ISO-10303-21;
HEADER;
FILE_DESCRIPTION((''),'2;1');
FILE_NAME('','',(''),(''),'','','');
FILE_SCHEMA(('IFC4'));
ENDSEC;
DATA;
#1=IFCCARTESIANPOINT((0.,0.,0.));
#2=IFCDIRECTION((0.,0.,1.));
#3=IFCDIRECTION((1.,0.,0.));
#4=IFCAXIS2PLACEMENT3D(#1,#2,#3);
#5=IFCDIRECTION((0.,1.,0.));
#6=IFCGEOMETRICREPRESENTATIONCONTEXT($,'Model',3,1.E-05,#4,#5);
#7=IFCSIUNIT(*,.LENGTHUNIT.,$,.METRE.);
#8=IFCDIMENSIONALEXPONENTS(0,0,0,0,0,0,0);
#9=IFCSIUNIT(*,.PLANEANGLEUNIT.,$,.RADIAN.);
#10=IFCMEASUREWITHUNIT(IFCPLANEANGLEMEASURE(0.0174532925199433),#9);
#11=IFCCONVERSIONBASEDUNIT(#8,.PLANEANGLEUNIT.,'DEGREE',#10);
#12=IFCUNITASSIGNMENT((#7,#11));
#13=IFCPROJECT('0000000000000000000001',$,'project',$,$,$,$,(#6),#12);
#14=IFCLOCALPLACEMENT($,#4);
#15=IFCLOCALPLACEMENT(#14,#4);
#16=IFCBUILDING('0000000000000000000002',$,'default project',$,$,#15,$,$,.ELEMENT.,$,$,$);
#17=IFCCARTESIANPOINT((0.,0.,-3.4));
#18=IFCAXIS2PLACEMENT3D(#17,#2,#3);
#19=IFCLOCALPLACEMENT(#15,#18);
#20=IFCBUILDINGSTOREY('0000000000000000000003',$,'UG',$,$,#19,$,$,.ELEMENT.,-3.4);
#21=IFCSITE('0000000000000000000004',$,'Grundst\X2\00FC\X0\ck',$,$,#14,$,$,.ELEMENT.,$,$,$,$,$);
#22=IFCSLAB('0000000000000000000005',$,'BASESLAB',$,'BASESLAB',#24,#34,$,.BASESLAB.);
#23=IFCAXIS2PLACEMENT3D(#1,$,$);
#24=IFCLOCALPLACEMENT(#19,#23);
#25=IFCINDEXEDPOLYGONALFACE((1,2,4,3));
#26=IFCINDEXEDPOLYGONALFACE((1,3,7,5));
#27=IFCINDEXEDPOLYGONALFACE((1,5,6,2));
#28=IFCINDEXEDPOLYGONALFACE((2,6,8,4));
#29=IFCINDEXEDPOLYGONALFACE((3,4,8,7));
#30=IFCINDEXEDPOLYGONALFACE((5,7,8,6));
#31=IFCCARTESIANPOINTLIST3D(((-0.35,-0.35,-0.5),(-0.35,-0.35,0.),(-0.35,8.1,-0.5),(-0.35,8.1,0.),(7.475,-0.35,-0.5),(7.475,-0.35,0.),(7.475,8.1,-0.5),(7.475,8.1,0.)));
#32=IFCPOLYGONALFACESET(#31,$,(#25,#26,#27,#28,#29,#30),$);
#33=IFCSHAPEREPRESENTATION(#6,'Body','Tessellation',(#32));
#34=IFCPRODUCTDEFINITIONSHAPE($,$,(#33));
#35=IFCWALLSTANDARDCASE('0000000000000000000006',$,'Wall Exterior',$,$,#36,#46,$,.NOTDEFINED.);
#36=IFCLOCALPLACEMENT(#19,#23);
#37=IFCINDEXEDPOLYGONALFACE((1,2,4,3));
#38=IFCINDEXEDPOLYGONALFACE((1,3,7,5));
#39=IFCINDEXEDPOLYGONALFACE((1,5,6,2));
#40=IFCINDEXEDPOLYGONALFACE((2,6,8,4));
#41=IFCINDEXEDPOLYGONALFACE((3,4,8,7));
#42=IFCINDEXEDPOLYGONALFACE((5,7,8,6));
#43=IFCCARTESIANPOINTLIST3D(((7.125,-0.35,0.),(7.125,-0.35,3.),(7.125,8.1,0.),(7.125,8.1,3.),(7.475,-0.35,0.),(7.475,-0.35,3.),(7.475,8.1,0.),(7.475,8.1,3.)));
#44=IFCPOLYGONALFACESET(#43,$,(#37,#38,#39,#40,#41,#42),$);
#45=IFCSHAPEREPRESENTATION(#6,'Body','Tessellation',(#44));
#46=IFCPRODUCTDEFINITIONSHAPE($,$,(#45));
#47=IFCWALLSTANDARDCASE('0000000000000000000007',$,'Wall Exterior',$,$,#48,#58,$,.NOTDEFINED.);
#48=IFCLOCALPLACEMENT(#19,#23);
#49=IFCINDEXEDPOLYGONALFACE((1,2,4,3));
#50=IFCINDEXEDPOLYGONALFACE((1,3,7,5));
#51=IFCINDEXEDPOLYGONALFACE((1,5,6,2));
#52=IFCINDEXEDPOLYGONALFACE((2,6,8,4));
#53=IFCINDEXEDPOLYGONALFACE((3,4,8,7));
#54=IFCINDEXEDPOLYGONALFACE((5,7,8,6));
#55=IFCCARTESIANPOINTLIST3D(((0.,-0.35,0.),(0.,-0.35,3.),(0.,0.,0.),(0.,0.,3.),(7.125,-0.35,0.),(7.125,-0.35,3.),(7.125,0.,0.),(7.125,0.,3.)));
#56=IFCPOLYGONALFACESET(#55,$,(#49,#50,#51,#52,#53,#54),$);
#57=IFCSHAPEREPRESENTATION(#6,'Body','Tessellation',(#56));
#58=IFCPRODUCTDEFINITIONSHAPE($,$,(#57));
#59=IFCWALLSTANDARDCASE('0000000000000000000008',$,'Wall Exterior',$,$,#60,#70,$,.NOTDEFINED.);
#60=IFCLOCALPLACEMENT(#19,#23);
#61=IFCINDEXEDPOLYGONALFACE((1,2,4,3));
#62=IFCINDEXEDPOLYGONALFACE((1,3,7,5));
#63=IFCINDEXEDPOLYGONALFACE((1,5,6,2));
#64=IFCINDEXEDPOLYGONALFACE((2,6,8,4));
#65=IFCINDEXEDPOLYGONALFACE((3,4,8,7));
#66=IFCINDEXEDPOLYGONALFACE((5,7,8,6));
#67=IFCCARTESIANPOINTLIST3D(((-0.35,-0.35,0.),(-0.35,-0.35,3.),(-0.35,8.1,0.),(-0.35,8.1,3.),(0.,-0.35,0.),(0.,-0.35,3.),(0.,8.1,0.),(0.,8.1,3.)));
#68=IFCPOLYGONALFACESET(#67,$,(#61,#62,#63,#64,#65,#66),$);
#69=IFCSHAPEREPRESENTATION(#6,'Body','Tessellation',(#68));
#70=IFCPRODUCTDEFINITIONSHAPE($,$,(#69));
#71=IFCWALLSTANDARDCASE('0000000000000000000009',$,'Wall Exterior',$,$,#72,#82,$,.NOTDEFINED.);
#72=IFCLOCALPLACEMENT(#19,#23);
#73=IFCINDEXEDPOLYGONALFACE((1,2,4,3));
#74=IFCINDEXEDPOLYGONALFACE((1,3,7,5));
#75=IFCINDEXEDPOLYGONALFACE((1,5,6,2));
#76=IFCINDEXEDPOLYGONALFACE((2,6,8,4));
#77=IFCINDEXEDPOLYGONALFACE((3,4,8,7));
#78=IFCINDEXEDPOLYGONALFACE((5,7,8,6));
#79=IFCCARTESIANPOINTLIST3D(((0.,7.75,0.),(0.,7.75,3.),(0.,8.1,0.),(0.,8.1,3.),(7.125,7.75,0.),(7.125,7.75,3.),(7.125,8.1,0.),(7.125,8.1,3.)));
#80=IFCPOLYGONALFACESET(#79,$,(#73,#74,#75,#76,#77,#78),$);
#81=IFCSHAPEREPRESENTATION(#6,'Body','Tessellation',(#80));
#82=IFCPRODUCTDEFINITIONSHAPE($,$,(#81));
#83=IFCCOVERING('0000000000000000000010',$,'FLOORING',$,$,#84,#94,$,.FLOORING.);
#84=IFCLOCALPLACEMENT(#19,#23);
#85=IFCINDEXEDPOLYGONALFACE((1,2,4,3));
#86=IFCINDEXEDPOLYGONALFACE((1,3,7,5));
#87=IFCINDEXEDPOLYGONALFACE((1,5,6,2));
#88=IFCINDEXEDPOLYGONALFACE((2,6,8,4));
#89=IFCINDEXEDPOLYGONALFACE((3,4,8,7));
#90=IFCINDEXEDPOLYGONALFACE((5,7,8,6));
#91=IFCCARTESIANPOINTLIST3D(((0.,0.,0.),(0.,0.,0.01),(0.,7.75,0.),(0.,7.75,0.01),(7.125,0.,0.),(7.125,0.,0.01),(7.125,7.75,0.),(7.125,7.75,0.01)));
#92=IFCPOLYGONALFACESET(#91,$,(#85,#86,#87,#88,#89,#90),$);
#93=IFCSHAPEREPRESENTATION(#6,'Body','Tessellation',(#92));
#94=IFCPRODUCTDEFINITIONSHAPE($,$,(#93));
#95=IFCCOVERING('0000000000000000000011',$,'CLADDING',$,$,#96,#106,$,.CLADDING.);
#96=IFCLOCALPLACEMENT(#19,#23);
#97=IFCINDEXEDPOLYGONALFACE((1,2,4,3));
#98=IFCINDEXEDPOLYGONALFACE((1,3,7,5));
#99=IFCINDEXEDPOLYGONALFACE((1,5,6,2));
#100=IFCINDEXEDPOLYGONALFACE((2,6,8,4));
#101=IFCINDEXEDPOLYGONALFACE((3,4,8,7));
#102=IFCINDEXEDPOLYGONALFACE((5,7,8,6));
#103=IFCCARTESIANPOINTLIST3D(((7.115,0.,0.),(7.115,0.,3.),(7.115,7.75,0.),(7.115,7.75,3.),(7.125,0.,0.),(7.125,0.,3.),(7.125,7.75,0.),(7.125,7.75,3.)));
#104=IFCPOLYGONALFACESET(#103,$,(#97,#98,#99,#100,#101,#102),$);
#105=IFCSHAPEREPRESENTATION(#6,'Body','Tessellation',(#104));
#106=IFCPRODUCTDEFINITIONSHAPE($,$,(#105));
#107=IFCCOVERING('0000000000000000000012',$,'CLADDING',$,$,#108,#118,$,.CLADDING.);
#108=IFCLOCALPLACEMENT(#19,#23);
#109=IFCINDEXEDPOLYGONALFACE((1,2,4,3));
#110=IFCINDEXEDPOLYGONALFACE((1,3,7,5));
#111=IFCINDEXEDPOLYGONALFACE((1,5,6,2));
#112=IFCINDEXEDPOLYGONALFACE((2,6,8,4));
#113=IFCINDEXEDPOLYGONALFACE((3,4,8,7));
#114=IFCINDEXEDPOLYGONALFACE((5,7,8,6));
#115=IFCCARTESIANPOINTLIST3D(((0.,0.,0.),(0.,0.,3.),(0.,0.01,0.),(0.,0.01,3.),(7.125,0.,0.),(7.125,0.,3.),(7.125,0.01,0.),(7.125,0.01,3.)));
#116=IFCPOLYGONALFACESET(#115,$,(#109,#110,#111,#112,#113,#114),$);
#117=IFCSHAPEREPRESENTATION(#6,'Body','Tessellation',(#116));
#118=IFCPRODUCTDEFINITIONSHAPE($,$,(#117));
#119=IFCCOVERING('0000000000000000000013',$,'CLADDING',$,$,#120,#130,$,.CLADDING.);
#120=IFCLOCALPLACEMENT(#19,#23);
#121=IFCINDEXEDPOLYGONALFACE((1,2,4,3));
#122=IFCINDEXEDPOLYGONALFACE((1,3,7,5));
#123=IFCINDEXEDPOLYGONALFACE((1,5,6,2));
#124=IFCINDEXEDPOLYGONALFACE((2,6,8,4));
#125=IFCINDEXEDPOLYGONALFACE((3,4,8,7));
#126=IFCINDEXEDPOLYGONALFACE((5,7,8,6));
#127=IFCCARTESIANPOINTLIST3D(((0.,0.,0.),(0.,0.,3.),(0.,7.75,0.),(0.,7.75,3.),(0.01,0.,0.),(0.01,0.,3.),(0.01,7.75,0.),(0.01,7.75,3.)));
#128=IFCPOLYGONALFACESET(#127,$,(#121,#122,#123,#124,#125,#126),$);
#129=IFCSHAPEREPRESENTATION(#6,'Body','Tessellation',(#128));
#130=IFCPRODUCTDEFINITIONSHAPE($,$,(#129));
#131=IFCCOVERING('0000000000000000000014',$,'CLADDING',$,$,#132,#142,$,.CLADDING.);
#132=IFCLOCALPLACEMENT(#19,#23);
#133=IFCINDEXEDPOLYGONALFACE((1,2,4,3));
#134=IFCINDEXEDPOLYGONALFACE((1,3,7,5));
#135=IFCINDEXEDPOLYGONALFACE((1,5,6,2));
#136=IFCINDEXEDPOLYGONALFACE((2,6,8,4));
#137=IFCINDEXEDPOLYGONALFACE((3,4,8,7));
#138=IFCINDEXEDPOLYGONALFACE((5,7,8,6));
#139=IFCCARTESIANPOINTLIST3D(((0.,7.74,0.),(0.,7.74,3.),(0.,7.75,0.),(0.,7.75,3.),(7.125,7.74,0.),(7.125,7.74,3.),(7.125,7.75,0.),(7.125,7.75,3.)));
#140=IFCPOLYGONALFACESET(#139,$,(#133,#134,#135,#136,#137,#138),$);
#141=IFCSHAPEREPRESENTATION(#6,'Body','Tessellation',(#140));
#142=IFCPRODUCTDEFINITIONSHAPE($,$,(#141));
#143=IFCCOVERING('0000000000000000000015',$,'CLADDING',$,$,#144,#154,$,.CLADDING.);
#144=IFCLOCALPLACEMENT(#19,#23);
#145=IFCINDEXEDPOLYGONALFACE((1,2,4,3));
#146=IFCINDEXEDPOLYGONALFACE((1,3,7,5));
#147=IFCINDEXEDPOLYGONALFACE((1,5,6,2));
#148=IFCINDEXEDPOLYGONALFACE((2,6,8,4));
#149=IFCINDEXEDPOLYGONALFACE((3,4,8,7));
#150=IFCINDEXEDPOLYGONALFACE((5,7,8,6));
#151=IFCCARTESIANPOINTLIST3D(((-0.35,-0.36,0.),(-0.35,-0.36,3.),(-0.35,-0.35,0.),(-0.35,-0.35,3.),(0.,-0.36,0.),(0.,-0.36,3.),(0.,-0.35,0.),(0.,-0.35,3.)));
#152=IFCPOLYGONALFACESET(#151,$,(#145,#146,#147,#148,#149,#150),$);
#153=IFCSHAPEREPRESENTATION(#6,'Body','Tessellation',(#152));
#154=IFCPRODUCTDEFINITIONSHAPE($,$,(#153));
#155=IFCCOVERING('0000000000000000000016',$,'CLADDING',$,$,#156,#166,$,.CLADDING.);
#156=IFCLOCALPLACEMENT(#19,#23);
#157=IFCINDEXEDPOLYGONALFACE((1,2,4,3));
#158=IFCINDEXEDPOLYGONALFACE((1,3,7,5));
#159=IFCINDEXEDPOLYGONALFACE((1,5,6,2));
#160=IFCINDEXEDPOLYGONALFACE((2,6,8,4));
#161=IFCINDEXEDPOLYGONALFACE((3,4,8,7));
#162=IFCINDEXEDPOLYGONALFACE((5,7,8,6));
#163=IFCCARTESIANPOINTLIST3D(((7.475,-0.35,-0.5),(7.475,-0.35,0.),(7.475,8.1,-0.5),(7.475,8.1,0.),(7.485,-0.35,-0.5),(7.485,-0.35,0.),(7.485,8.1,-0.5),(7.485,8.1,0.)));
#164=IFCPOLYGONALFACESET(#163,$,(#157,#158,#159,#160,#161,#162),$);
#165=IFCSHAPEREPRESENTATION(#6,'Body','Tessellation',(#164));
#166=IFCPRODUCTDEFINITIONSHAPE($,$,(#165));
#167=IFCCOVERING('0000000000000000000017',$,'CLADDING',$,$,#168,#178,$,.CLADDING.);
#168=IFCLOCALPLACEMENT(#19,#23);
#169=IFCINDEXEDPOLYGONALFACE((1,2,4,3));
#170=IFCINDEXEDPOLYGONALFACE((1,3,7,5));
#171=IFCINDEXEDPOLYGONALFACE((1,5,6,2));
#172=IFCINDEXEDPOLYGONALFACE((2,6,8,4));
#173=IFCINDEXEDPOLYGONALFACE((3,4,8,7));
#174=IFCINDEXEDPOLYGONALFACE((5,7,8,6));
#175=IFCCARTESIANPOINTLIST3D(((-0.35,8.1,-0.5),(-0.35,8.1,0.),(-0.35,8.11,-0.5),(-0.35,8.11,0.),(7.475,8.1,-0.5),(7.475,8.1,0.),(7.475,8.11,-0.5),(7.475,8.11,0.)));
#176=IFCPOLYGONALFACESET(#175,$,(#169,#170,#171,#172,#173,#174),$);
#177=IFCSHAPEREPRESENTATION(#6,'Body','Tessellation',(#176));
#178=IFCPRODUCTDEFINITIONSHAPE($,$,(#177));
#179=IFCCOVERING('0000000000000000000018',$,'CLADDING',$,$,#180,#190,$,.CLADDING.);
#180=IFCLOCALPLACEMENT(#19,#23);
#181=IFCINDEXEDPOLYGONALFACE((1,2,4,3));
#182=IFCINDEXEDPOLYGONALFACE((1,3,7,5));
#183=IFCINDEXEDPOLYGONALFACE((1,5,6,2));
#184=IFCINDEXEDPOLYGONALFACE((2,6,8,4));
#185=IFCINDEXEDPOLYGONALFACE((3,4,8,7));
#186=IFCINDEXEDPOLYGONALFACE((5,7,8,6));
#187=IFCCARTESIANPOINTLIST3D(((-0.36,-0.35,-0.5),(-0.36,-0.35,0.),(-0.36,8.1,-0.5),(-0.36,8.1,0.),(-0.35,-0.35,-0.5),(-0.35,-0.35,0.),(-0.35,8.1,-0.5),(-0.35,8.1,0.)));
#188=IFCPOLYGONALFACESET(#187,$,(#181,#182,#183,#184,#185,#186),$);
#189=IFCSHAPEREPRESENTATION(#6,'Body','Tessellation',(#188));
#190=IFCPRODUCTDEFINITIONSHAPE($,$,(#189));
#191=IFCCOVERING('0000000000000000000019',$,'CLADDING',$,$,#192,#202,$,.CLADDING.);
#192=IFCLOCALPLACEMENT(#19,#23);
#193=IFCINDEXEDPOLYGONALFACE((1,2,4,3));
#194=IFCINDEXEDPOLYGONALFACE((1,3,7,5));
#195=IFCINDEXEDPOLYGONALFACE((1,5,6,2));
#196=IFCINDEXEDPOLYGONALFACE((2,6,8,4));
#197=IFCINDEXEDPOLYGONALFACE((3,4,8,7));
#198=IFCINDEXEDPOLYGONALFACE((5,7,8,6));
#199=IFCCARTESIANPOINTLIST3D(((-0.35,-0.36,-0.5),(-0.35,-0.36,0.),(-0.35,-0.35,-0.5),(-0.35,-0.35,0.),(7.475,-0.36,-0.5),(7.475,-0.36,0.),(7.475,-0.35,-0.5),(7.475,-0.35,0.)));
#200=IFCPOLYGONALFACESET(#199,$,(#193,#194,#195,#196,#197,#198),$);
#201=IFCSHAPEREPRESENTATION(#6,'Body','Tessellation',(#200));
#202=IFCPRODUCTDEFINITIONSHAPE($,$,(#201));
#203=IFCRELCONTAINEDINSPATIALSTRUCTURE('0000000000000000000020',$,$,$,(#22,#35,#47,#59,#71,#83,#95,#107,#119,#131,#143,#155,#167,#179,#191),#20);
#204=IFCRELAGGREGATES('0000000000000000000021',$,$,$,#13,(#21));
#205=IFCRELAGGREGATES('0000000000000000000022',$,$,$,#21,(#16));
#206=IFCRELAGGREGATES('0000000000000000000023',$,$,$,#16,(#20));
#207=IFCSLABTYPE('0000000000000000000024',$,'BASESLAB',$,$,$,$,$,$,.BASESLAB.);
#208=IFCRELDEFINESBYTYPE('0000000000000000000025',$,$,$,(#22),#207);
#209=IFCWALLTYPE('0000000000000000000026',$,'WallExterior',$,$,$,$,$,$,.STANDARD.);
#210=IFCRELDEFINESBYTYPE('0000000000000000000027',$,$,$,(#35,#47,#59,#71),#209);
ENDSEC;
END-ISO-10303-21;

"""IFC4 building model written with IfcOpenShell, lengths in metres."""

from ifc_helpers import new_model, entity, si_unit, converted_unit, direction, frame, origin_with_axes, place, context, project, spatial, polyline, outline, extrude, type_object, element, save


model = new_model("IFC4")

# Units and contexts
model_context = context("Model", 3, precision=1e-05, world=origin_with_axes(), true_north=direction((0.0, 1.0, 0.0)))
ifc_project = project(units=[si_unit("LENGTHUNIT", "METRE"), converted_unit("PLANEANGLEUNIT", "DEGREE", entity("IfcPlaneAngleMeasure", 0.0174532925199433), si_unit("PLANEANGLEUNIT", "RADIAN"), dimensions=[0, 0, 0, 0, 0, 0, 0])], contexts=[model_context])

# Site, building, storey
site_placement = place(None, origin_with_axes())
site = spatial("IfcSite", under=ifc_project, at=site_placement, Name="Grundstück", CompositionType="ELEMENT")
building_placement = place(site_placement, origin_with_axes())
building = spatial("IfcBuilding", under=site, at=building_placement, Name="default project", CompositionType="ELEMENT")
placement_1 = place(building_placement, frame((0.0, 0.0, -3.4), z_axis=(0.0, 0.0, 1.0), x_axis=(1.0, 0.0, 0.0)))
storey = spatial("IfcBuildingStorey", under=building, at=placement_1, Name="UG", CompositionType="ELEMENT", Elevation=-3.4)

# Slab
slab_type = type_object("IfcSlabType", Name="BASESLAB", PredefinedType="BASESLAB")
slab_placement = place(placement_1, frame((0.0, 0.0, -0.5), z_axis=(0.0, 0.0, 1.0), x_axis=(1.0, 0.0, 0.0)))
element("IfcSlab", 1, at=slab_placement, inside=storey, type_object=slab_type, Name="BASESLAB", ObjectType="BASESLAB", PredefinedType="BASESLAB", context=model_context, shape_type="SweptSolid", body=[
    extrude(outline(polyline([(7.475, 8.1), (-0.35, 8.1), (-0.35, -0.35), (7.475, -0.35), (7.475, 8.1)])), origin_with_axes(), (0.0, 0.0, 1.0), 0.5),
])

# Walls
wall_type = type_object("IfcWallType", Name="WallExterior", PredefinedType="STANDARD")
placement_2 = place(placement_1, frame((7.3, 7.925, 0.0), z_axis=(0.0, 0.0, 1.0), x_axis=(0.0, -1.0, 0.0)))
element("IfcWallStandardCase", 2, at=placement_2, inside=storey, type_object=wall_type, Name="Wall Exterior", PredefinedType="NOTDEFINED", context=model_context, shape_type="SweptSolid", body=[
    extrude(outline(polyline([(-0.175, -0.175), (8.275, -0.175), (8.275, 0.175), (-0.175, 0.175), (-0.175, -0.175)])), origin_with_axes(), (0.0, 0.0, 1.0), 3.0),
])
placement_3 = place(placement_1, frame((7.3, -0.175, 0.0), z_axis=(0.0, 0.0, 1.0), x_axis=(-1.0, 0.0, 0.0)))
element("IfcWallStandardCase", 3, at=placement_3, inside=storey, type_object=wall_type, Name="Wall Exterior", PredefinedType="NOTDEFINED", context=model_context, shape_type="SweptSolid", body=[
    extrude(outline(polyline([(0.175, -0.175), (7.3, -0.175), (7.3, 0.175), (0.175, 0.175), (0.175, -0.175)])), origin_with_axes(), (0.0, 0.0, 1.0), 3.0),
])
placement_4 = place(placement_1, frame((-0.175, -0.175, 0.0), z_axis=(0.0, 0.0, 1.0), x_axis=(0.0, 1.0, 0.0)))
element("IfcWallStandardCase", 4, at=placement_4, inside=storey, type_object=wall_type, Name="Wall Exterior", PredefinedType="NOTDEFINED", context=model_context, shape_type="SweptSolid", body=[
    extrude(outline(polyline([(-0.175, -0.175), (8.275, -0.175), (8.275, 0.175), (-0.175, 0.175), (-0.175, -0.175)])), origin_with_axes(), (0.0, 0.0, 1.0), 3.0),
])
placement_5 = place(placement_1, frame((-0.175, 7.925, 0.0), z_axis=(0.0, 0.0, 1.0), x_axis=(1.0, 0.0, 0.0)))
element("IfcWallStandardCase", 5, at=placement_5, inside=storey, type_object=wall_type, Name="Wall Exterior", PredefinedType="NOTDEFINED", context=model_context, shape_type="SweptSolid", body=[
    extrude(outline(polyline([(7.3, 0.175), (0.175, 0.175), (0.175, -0.175), (7.3, -0.175), (7.3, 0.175)])), origin_with_axes(), (0.0, 0.0, 1.0), 3.0),
])

# Coverings
element("IfcCovering", 6, at=placement_1, inside=storey, Name="FLOORING", PredefinedType="FLOORING", context=model_context, shape_type="SweptSolid", body=[
    extrude(outline(polyline([(7.125, 7.75), (0.0, 7.75), (0.0, 0.0), (7.125, 0.0), (7.125, 7.75)])), origin_with_axes(), (0.0, 0.0, 1.0), 0.01),
])
element("IfcCovering", 7, at=placement_1, inside=storey, Name="CLADDING", PredefinedType="CLADDING", context=model_context, shape_type="SweptSolid", body=[
    extrude(outline(polyline([(7.115, 7.75), (7.115, 0.0), (7.125, 0.0), (7.125, 7.75), (7.115, 7.75)])), origin_with_axes(), (0.0, 0.0, 1.0), 3.0),
])
element("IfcCovering", 8, at=placement_1, inside=storey, Name="CLADDING", PredefinedType="CLADDING", context=model_context, shape_type="SweptSolid", body=[
    extrude(outline(polyline([(7.125, 0.01), (0.0, 0.01), (0.0, 0.0), (7.125, 0.0), (7.125, 0.01)])), origin_with_axes(), (0.0, 0.0, 1.0), 3.0),
])
element("IfcCovering", 9, at=placement_1, inside=storey, Name="CLADDING", PredefinedType="CLADDING", context=model_context, shape_type="SweptSolid", body=[
    extrude(outline(polyline([(0.01, 0.0), (0.01, 7.75), (0.0, 7.75), (0.0, 0.0), (0.01, 0.0)])), origin_with_axes(), (0.0, 0.0, 1.0), 3.0),
])
element("IfcCovering", 10, at=placement_1, inside=storey, Name="CLADDING", PredefinedType="CLADDING", context=model_context, shape_type="SweptSolid", body=[
    extrude(outline(polyline([(0.0, 7.74), (7.125, 7.74), (7.125, 7.75), (0.0, 7.75), (0.0, 7.74)])), origin_with_axes(), (0.0, 0.0, 1.0), 3.0),
])
element("IfcCovering", 11, at=placement_4, inside=storey, Name="CLADDING", PredefinedType="CLADDING", context=model_context, shape_type="SweptSolid", body=[
    extrude(outline(polyline([(-0.185, 0.175), (-0.185, -0.175), (-0.175, -0.175), (-0.175, 0.175), (-0.185, 0.175)])), origin_with_axes(), (0.0, 0.0, 1.0), 3.0),
])
covering_1_placement = place(slab_placement, origin_with_axes())
element("IfcCovering", 12, at=covering_1_placement, inside=storey, Name="CLADDING", PredefinedType="CLADDING", context=model_context, shape_type="SweptSolid", body=[
    extrude(outline(polyline([(7.485, -0.35), (7.485, 8.1), (7.475, 8.1), (7.475, -0.35), (7.485, -0.35)])), origin_with_axes(), (0.0, 0.0, 1.0), 0.5),
])
covering_2_placement = place(slab_placement, origin_with_axes())
element("IfcCovering", 13, at=covering_2_placement, inside=storey, Name="CLADDING", PredefinedType="CLADDING", context=model_context, shape_type="SweptSolid", body=[
    extrude(outline(polyline([(7.475, 8.11), (-0.35, 8.11), (-0.35, 8.1), (7.475, 8.1), (7.475, 8.11)])), origin_with_axes(), (0.0, 0.0, 1.0), 0.5),
])
covering_3_placement = place(slab_placement, origin_with_axes())
element("IfcCovering", 14, at=covering_3_placement, inside=storey, Name="CLADDING", PredefinedType="CLADDING", context=model_context, shape_type="SweptSolid", body=[
    extrude(outline(polyline([(-0.36, 8.1), (-0.36, -0.35), (-0.35, -0.35), (-0.35, 8.1), (-0.36, 8.1)])), origin_with_axes(), (0.0, 0.0, 1.0), 0.5),
])
covering_4_placement = place(slab_placement, origin_with_axes())
element("IfcCovering", 15, at=covering_4_placement, inside=storey, Name="CLADDING", PredefinedType="CLADDING", context=model_context, shape_type="SweptSolid", body=[
    extrude(outline(polyline([(-0.35, -0.36), (7.475, -0.36), (7.475, -0.35), (-0.35, -0.35), (-0.35, -0.36)])), origin_with_axes(), (0.0, 0.0, 1.0), 0.5),
])

save(model, "model.ifc")
